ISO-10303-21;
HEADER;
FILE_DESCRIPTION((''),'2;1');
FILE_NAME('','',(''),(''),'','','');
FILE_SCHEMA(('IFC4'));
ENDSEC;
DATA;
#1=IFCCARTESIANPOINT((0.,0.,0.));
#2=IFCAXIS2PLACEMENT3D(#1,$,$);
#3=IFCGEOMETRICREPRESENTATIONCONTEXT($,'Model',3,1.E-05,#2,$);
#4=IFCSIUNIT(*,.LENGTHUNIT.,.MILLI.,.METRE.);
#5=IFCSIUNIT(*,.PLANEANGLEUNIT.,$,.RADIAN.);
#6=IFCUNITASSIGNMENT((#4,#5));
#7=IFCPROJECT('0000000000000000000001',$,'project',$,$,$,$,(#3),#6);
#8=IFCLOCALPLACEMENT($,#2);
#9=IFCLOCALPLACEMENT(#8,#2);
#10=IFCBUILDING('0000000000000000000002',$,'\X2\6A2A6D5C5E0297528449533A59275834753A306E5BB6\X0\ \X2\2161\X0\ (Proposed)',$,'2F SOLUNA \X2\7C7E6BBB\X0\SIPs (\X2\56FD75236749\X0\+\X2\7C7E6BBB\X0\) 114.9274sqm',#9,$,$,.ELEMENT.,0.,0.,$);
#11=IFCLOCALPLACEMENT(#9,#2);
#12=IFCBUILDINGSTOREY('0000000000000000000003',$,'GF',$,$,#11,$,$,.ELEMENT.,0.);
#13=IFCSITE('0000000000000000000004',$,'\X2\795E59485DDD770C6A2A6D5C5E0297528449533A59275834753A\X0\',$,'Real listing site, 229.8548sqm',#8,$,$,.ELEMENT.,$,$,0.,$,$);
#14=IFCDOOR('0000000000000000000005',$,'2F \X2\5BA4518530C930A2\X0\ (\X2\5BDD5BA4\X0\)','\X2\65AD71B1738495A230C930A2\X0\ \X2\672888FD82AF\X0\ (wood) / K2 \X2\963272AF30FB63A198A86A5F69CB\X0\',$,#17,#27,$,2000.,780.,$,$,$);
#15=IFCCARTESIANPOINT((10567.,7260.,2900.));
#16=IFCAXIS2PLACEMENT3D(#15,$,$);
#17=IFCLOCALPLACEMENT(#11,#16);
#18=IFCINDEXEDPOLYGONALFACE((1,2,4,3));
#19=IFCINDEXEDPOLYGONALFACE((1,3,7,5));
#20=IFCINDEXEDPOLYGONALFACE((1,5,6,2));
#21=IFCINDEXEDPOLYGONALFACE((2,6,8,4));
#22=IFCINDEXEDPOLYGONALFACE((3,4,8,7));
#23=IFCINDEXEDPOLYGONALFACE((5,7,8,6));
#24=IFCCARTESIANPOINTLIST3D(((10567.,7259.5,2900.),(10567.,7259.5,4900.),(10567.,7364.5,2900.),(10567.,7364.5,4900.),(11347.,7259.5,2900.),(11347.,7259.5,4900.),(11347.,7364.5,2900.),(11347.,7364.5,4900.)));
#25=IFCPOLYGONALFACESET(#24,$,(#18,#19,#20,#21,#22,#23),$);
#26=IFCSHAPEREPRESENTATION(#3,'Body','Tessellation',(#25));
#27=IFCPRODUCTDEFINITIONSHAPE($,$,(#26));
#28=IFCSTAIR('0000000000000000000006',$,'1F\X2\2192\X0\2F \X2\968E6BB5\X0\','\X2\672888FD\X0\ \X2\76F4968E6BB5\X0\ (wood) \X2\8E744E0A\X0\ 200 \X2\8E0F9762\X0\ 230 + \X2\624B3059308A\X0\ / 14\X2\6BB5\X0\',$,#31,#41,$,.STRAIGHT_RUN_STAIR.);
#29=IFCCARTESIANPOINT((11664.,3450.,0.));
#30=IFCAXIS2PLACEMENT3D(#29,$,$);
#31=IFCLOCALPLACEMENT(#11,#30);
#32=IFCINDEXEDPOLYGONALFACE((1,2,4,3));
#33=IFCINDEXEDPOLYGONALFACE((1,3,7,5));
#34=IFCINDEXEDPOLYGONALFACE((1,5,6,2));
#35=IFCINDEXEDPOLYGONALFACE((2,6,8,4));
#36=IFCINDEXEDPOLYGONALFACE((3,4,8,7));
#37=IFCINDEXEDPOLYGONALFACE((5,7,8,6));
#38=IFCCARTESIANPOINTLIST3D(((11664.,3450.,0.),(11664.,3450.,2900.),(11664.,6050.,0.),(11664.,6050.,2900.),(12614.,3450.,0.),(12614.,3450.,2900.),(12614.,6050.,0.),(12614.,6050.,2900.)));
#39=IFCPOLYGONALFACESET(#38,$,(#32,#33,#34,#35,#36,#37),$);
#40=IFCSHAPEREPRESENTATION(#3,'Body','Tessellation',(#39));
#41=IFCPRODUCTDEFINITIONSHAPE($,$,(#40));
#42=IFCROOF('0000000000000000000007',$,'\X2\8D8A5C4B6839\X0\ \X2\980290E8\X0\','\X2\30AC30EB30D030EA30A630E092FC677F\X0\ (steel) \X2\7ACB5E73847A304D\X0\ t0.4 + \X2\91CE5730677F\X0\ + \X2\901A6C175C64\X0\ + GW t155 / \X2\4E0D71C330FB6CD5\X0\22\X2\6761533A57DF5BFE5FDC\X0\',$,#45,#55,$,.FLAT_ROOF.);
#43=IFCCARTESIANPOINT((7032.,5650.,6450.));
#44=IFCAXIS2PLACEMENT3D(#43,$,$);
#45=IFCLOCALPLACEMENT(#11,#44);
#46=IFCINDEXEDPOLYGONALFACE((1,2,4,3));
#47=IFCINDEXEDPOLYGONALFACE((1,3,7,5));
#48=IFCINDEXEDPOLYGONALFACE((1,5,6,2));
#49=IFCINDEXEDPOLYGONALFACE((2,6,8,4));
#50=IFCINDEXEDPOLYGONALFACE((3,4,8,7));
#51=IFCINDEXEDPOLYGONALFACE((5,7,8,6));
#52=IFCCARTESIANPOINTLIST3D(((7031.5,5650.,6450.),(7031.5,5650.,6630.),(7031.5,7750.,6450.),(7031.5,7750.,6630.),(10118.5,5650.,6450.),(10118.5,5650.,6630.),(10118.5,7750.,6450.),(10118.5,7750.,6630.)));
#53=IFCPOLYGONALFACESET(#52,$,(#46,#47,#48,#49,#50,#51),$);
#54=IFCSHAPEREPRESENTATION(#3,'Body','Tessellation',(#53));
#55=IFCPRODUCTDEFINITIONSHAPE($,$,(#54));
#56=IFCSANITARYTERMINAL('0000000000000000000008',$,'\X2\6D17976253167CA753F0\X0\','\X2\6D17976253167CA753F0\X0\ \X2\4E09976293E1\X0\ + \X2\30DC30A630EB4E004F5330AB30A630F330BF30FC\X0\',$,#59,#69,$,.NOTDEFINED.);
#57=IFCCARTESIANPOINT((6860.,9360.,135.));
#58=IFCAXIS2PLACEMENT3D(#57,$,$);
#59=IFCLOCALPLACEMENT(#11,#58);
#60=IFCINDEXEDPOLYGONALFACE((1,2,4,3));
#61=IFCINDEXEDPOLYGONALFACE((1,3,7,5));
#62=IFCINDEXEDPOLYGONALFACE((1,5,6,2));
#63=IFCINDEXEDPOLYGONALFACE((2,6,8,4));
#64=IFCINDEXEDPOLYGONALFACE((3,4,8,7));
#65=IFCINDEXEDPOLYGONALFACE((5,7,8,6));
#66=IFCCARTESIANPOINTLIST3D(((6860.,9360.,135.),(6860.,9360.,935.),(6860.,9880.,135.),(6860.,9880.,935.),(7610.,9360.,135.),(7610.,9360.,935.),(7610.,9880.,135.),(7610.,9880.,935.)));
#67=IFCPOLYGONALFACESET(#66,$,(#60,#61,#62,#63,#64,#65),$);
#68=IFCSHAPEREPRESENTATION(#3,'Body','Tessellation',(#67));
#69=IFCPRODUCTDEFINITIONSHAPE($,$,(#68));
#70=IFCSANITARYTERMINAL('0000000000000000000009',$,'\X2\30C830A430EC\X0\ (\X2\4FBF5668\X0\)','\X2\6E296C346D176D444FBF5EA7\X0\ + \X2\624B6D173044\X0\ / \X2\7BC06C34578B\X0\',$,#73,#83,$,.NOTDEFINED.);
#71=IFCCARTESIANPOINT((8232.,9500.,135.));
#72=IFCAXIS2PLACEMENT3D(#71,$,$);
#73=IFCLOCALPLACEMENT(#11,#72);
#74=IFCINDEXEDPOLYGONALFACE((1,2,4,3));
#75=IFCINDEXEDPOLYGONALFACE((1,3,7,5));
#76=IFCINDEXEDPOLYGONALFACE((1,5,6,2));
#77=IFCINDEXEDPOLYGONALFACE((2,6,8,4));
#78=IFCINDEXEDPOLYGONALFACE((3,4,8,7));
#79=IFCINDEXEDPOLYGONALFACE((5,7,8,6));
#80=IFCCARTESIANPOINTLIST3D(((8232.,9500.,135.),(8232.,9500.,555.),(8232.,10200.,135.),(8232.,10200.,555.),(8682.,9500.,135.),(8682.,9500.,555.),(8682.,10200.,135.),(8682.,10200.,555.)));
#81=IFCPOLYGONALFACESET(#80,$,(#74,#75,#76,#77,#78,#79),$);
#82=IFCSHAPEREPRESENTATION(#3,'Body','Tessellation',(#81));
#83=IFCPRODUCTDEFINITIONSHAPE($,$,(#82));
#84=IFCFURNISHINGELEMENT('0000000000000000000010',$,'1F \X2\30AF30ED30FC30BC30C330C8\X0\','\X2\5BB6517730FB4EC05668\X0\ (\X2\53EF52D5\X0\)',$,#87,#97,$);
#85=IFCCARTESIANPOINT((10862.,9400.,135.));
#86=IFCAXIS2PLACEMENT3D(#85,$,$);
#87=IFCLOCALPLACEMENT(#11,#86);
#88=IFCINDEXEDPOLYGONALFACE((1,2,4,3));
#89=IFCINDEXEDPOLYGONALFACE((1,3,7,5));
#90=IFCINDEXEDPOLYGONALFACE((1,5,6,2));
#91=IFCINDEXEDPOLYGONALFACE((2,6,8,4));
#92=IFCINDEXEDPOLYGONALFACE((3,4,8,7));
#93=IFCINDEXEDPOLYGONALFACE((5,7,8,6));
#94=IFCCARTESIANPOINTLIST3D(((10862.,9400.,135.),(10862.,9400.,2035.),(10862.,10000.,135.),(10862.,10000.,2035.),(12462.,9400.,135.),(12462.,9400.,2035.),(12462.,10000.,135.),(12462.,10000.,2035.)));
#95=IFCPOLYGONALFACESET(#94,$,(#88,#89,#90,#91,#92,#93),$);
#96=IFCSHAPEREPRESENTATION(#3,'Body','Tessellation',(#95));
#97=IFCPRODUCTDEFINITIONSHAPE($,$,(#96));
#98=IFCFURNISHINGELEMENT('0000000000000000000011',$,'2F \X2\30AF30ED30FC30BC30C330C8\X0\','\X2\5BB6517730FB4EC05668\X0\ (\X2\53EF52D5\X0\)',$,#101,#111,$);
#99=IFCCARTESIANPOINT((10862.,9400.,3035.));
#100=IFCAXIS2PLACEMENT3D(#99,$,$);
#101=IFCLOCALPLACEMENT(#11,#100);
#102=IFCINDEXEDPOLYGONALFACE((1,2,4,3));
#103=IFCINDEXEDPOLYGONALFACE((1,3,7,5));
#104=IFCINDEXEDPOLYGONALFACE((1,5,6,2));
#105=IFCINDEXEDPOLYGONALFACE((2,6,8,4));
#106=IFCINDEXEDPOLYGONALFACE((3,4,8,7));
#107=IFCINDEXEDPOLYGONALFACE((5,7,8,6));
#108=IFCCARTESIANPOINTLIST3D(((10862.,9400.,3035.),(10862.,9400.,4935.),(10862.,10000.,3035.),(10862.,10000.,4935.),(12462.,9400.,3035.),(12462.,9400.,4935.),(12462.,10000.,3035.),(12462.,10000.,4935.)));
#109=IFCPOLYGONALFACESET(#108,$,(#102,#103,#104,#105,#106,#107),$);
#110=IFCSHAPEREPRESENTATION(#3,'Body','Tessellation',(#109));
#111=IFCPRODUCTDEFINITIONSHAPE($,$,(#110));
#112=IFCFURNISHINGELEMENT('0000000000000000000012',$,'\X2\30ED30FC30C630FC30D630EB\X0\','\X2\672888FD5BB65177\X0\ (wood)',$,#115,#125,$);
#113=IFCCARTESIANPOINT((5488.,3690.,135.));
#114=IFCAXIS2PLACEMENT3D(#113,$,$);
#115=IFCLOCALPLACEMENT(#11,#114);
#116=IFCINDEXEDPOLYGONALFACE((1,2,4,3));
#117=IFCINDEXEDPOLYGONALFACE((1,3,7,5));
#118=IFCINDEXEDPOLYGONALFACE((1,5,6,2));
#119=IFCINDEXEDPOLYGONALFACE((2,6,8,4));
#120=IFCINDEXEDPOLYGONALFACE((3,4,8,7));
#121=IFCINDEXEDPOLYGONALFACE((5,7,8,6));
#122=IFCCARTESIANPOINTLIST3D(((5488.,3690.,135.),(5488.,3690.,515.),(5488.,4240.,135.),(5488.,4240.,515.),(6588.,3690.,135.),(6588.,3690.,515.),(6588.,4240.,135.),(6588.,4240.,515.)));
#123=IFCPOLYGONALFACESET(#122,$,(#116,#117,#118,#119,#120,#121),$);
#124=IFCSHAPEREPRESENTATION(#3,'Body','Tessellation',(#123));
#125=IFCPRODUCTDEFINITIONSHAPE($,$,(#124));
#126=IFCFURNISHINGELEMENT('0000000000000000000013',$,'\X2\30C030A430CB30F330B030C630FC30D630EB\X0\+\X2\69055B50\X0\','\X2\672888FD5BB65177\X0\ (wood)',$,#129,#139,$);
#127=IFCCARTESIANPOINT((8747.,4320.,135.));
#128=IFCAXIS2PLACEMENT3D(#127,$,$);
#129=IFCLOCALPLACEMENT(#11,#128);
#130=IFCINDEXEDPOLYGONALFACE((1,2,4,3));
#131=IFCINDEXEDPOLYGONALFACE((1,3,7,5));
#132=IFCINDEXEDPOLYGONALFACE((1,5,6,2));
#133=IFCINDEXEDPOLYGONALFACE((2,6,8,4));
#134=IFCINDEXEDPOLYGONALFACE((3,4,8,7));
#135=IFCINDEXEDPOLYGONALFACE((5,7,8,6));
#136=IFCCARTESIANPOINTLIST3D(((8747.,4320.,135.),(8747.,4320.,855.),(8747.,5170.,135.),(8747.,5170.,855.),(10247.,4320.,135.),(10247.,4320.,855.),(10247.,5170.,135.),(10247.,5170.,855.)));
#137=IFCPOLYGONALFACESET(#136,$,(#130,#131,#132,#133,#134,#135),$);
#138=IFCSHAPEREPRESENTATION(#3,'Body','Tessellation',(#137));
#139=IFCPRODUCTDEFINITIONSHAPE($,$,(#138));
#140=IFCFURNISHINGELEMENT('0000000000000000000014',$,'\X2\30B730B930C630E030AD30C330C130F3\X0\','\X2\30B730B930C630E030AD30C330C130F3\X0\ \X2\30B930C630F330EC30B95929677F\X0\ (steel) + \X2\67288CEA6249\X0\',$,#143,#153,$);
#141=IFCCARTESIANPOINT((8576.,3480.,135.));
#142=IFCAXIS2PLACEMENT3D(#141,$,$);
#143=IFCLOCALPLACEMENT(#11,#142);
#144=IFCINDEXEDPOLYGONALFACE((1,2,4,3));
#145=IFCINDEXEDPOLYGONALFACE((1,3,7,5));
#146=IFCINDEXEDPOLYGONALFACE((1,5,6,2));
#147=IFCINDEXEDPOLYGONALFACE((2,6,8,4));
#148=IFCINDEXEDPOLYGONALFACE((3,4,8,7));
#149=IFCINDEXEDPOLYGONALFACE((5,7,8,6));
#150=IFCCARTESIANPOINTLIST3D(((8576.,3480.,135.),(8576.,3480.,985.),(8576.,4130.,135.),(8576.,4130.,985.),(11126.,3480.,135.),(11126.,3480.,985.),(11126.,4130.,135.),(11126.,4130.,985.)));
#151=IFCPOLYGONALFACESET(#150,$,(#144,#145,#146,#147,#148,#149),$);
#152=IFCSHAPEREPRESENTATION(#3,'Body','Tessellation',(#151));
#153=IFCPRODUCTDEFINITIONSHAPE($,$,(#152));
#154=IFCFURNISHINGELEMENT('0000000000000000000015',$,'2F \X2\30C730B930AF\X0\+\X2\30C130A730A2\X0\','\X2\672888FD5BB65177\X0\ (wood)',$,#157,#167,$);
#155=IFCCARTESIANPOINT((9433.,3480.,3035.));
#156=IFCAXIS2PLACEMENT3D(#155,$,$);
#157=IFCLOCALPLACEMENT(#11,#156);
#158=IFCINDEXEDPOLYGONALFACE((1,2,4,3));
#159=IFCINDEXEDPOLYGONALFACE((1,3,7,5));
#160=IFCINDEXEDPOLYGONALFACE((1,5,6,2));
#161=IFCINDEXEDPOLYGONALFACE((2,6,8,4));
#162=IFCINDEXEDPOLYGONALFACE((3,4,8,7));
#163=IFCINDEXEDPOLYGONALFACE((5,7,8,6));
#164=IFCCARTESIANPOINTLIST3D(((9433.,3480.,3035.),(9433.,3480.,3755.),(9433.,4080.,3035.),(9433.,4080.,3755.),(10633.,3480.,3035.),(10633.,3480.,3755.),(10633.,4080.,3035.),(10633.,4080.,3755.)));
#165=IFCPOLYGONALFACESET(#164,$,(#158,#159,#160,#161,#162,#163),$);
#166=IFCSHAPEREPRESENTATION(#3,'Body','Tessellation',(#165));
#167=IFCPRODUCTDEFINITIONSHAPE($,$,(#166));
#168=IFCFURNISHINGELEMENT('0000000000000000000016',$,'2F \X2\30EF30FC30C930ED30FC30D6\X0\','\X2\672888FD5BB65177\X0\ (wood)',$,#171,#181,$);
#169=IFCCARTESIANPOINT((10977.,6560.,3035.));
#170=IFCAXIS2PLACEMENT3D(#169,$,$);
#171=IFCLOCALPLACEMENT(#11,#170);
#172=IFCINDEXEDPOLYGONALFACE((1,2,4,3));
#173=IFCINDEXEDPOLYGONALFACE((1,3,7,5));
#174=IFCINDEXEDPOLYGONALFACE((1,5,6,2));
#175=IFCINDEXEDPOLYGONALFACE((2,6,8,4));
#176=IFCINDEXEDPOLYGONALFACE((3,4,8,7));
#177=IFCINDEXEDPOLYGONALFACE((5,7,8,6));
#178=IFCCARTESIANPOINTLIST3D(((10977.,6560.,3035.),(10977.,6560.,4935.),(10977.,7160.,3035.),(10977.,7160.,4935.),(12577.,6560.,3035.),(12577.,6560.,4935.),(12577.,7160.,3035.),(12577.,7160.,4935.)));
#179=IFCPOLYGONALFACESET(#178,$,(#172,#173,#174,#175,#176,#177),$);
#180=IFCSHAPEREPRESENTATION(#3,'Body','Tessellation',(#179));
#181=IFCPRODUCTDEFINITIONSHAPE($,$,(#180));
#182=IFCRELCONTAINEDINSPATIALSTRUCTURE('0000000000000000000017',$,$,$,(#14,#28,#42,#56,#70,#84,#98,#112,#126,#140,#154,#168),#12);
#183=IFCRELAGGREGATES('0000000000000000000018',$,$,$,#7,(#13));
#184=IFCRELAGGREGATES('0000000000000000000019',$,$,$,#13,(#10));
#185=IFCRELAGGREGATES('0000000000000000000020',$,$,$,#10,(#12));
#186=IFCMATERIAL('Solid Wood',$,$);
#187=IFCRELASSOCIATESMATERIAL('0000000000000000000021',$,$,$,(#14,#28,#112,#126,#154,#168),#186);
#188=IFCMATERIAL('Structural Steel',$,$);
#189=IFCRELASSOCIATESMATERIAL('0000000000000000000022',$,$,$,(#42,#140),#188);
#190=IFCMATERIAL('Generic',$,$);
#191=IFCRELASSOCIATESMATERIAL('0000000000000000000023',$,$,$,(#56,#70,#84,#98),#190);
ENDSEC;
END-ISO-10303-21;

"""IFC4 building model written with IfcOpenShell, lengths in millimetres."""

from ifc_helpers import new_model, si_unit, frame, frame_2d, origin, place, context, project, spatial, rectangle, extrude, material, element, save


model = new_model("IFC4")

# Units and contexts
model_context = context("Model", 3, precision=1e-05, world=origin())
ifc_project = project(units=[si_unit("LENGTHUNIT", "METRE", prefix="MILLI"), si_unit("PLANEANGLEUNIT", "RADIAN")], contexts=[model_context])

# Site, building, storey
site_placement = place(None, origin())
site = spatial("IfcSite", under=ifc_project, at=site_placement, Name="神奈川県横浜市青葉区大場町", ObjectType="Real listing site, 229.8548sqm", CompositionType="ELEMENT", RefElevation=0.0)
building_placement = place(site_placement, origin())
building = spatial("IfcBuilding", under=site, at=building_placement, Name="横浜市青葉区大場町の家 Ⅱ (Proposed)", ObjectType="2F SOLUNA 籾殻SIPs (国産杉+籾殻) 114.9274sqm", CompositionType="ELEMENT", ElevationOfRefHeight=0.0, ElevationOfTerrain=0.0)
storey_placement = place(building_placement, origin())
storey = spatial("IfcBuildingStorey", under=building, at=storey_placement, Name="GF", CompositionType="ELEMENT", Elevation=0.0)

# Shared definitions
ifc_material_1 = material(Name="Solid Wood")

# Door
door_1_placement = place(storey_placement, frame((10567.0, 7260.0, 2900.0)))
element("IfcDoor", 1, at=door_1_placement, inside=storey, material=ifc_material_1, Name="2F 室内ドア (寝室)", Description="断熱玄関ドア 木製芯 (wood) / K2 防犯・採風機構", OverallHeight=2000.0, OverallWidth=780.0, context=model_context, shape_type="SweptSolid", body=[
    extrude(rectangle(XDim=780.0, YDim=105.0, at=frame_2d((390.0, 52.0))), frame((10567.0, 7260.0, 2900.0)), (0.0, 0.0, 1.0), 2000.0),
])

# Stair
stair_placement = place(storey_placement, frame((11664.0, 3450.0, 0.0)))
element("IfcStair", 2, at=stair_placement, inside=storey, material=ifc_material_1, Name="1F→2F 階段", Description="木製 直階段 (wood) 蹴上 200 踏面 230 + 手すり / 14段", PredefinedType="STRAIGHT_RUN_STAIR", context=model_context, shape_type="SweptSolid", body=[
    extrude(rectangle(XDim=950.0, YDim=2600.0, at=frame_2d((475.0, 1300.0))), frame((11664.0, 3450.0, 0.0)), (0.0, 0.0, 1.0), 2900.0),
])

# Roof
ifc_material_2 = material(Name="Structural Steel")
roof_placement = place(storey_placement, frame((7032.0, 5650.0, 6450.0)))
element("IfcRoof", 3, at=roof_placement, inside=storey, material=ifc_material_2, Name="越屋根 頂部", Description="ガルバリウム鋼板 (steel) 立平葺き t0.4 + 野地板 + 通気層 + GW t155 / 不燃・法22条区域対応", PredefinedType="FLAT_ROOF", context=model_context, shape_type="SweptSolid", body=[
    extrude(rectangle(XDim=3087.0, YDim=2100.0, at=frame_2d((1543.0, 1050.0))), frame((7032.0, 5650.0, 6450.0)), (0.0, 0.0, 1.0), 180.0),
])

# Sanitary terminals
ifc_material_3 = material(Name="Generic")
sanitary_terminal_1_placement = place(storey_placement, frame((6860.0, 9360.0, 135.0)))
element("IfcSanitaryTerminal", 4, at=sanitary_terminal_1_placement, inside=storey, material=ifc_material_3, Name="洗面化粧台", Description="洗面化粧台 三面鏡 + ボウル一体カウンター", PredefinedType="NOTDEFINED", context=model_context, shape_type="SweptSolid", body=[
    extrude(rectangle(XDim=750.0, YDim=520.0, at=frame_2d((375.0, 260.0))), frame((6860.0, 9360.0, 135.0)), (0.0, 0.0, 1.0), 800.0),
])
sanitary_terminal_2_placement = place(storey_placement, frame((8232.0, 9500.0, 135.0)))
element("IfcSanitaryTerminal", 5, at=sanitary_terminal_2_placement, inside=storey, material=ifc_material_3, Name="トイレ (便器)", Description="温水洗浄便座 + 手洗い / 節水型", PredefinedType="NOTDEFINED", context=model_context, shape_type="SweptSolid", body=[
    extrude(rectangle(XDim=450.0, YDim=700.0, at=frame_2d((225.0, 350.0))), frame((8232.0, 9500.0, 135.0)), (0.0, 0.0, 1.0), 420.0),
])

# Furnishing elements
furnishing_1_placement = place(storey_placement, frame((10862.0, 9400.0, 135.0)))
element("IfcFurnishingElement", 6, at=furnishing_1_placement, inside=storey, material=ifc_material_3, Name="1F クローゼット", Description="家具・什器 (可動)", context=model_context, shape_type="SweptSolid", body=[
    extrude(rectangle(XDim=1600.0, YDim=600.0, at=frame_2d((800.0, 300.0))), frame((10862.0, 9400.0, 135.0)), (0.0, 0.0, 1.0), 1900.0),
])
furnishing_2_placement = place(storey_placement, frame((10862.0, 9400.0, 3035.0)))
element("IfcFurnishingElement", 7, at=furnishing_2_placement, inside=storey, material=ifc_material_3, Name="2F クローゼット", Description="家具・什器 (可動)", context=model_context, shape_type="SweptSolid", body=[
    extrude(rectangle(XDim=1600.0, YDim=600.0, at=frame_2d((800.0, 300.0))), frame((10862.0, 9400.0, 3035.0)), (0.0, 0.0, 1.0), 1900.0),
])
furnishing_3_placement = place(storey_placement, frame((5488.0, 3690.0, 135.0)))
element("IfcFurnishingElement", 8, at=furnishing_3_placement, inside=storey, material=ifc_material_1, Name="ローテーブル", Description="木製家具 (wood)", context=model_context, shape_type="SweptSolid", body=[
    extrude(rectangle(XDim=1100.0, YDim=550.0, at=frame_2d((550.0, 275.0))), frame((5488.0, 3690.0, 135.0)), (0.0, 0.0, 1.0), 380.0),
])
furnishing_4_placement = place(storey_placement, frame((8747.0, 4320.0, 135.0)))
element("IfcFurnishingElement", 9, at=furnishing_4_placement, inside=storey, material=ifc_material_1, Name="ダイニングテーブル+椅子", Description="木製家具 (wood)", context=model_context, shape_type="SweptSolid", body=[
    extrude(rectangle(XDim=1500.0, YDim=850.0, at=frame_2d((750.0, 425.0))), frame((8747.0, 4320.0, 135.0)), (0.0, 0.0, 1.0), 720.0),
])
furnishing_5_placement = place(storey_placement, frame((8576.0, 3480.0, 135.0)))
element("IfcFurnishingElement", 10, at=furnishing_5_placement, inside=storey, material=ifc_material_2, Name="システムキッチン", Description="システムキッチン ステンレス天板 (steel) + 木質扉", context=model_context, shape_type="SweptSolid", body=[
    extrude(rectangle(XDim=2550.0, YDim=650.0, at=frame_2d((1275.0, 325.0))), frame((8576.0, 3480.0, 135.0)), (0.0, 0.0, 1.0), 850.0),
])
furnishing_6_placement = place(storey_placement, frame((9433.0, 3480.0, 3035.0)))
element("IfcFurnishingElement", 11, at=furnishing_6_placement, inside=storey, material=ifc_material_1, Name="2F デスク+チェア", Description="木製家具 (wood)", context=model_context, shape_type="SweptSolid", body=[
    extrude(rectangle(XDim=1200.0, YDim=600.0, at=frame_2d((600.0, 300.0))), frame((9433.0, 3480.0, 3035.0)), (0.0, 0.0, 1.0), 720.0),
])
furnishing_7_placement = place(storey_placement, frame((10977.0, 6560.0, 3035.0)))
element("IfcFurnishingElement", 12, at=furnishing_7_placement, inside=storey, material=ifc_material_1, Name="2F ワードローブ", Description="木製家具 (wood)", context=model_context, shape_type="SweptSolid", body=[
    extrude(rectangle(XDim=1600.0, YDim=600.0, at=frame_2d((800.0, 300.0))), frame((10977.0, 6560.0, 3035.0)), (0.0, 0.0, 1.0), 1900.0),
])

save(model, "model.ifc")
